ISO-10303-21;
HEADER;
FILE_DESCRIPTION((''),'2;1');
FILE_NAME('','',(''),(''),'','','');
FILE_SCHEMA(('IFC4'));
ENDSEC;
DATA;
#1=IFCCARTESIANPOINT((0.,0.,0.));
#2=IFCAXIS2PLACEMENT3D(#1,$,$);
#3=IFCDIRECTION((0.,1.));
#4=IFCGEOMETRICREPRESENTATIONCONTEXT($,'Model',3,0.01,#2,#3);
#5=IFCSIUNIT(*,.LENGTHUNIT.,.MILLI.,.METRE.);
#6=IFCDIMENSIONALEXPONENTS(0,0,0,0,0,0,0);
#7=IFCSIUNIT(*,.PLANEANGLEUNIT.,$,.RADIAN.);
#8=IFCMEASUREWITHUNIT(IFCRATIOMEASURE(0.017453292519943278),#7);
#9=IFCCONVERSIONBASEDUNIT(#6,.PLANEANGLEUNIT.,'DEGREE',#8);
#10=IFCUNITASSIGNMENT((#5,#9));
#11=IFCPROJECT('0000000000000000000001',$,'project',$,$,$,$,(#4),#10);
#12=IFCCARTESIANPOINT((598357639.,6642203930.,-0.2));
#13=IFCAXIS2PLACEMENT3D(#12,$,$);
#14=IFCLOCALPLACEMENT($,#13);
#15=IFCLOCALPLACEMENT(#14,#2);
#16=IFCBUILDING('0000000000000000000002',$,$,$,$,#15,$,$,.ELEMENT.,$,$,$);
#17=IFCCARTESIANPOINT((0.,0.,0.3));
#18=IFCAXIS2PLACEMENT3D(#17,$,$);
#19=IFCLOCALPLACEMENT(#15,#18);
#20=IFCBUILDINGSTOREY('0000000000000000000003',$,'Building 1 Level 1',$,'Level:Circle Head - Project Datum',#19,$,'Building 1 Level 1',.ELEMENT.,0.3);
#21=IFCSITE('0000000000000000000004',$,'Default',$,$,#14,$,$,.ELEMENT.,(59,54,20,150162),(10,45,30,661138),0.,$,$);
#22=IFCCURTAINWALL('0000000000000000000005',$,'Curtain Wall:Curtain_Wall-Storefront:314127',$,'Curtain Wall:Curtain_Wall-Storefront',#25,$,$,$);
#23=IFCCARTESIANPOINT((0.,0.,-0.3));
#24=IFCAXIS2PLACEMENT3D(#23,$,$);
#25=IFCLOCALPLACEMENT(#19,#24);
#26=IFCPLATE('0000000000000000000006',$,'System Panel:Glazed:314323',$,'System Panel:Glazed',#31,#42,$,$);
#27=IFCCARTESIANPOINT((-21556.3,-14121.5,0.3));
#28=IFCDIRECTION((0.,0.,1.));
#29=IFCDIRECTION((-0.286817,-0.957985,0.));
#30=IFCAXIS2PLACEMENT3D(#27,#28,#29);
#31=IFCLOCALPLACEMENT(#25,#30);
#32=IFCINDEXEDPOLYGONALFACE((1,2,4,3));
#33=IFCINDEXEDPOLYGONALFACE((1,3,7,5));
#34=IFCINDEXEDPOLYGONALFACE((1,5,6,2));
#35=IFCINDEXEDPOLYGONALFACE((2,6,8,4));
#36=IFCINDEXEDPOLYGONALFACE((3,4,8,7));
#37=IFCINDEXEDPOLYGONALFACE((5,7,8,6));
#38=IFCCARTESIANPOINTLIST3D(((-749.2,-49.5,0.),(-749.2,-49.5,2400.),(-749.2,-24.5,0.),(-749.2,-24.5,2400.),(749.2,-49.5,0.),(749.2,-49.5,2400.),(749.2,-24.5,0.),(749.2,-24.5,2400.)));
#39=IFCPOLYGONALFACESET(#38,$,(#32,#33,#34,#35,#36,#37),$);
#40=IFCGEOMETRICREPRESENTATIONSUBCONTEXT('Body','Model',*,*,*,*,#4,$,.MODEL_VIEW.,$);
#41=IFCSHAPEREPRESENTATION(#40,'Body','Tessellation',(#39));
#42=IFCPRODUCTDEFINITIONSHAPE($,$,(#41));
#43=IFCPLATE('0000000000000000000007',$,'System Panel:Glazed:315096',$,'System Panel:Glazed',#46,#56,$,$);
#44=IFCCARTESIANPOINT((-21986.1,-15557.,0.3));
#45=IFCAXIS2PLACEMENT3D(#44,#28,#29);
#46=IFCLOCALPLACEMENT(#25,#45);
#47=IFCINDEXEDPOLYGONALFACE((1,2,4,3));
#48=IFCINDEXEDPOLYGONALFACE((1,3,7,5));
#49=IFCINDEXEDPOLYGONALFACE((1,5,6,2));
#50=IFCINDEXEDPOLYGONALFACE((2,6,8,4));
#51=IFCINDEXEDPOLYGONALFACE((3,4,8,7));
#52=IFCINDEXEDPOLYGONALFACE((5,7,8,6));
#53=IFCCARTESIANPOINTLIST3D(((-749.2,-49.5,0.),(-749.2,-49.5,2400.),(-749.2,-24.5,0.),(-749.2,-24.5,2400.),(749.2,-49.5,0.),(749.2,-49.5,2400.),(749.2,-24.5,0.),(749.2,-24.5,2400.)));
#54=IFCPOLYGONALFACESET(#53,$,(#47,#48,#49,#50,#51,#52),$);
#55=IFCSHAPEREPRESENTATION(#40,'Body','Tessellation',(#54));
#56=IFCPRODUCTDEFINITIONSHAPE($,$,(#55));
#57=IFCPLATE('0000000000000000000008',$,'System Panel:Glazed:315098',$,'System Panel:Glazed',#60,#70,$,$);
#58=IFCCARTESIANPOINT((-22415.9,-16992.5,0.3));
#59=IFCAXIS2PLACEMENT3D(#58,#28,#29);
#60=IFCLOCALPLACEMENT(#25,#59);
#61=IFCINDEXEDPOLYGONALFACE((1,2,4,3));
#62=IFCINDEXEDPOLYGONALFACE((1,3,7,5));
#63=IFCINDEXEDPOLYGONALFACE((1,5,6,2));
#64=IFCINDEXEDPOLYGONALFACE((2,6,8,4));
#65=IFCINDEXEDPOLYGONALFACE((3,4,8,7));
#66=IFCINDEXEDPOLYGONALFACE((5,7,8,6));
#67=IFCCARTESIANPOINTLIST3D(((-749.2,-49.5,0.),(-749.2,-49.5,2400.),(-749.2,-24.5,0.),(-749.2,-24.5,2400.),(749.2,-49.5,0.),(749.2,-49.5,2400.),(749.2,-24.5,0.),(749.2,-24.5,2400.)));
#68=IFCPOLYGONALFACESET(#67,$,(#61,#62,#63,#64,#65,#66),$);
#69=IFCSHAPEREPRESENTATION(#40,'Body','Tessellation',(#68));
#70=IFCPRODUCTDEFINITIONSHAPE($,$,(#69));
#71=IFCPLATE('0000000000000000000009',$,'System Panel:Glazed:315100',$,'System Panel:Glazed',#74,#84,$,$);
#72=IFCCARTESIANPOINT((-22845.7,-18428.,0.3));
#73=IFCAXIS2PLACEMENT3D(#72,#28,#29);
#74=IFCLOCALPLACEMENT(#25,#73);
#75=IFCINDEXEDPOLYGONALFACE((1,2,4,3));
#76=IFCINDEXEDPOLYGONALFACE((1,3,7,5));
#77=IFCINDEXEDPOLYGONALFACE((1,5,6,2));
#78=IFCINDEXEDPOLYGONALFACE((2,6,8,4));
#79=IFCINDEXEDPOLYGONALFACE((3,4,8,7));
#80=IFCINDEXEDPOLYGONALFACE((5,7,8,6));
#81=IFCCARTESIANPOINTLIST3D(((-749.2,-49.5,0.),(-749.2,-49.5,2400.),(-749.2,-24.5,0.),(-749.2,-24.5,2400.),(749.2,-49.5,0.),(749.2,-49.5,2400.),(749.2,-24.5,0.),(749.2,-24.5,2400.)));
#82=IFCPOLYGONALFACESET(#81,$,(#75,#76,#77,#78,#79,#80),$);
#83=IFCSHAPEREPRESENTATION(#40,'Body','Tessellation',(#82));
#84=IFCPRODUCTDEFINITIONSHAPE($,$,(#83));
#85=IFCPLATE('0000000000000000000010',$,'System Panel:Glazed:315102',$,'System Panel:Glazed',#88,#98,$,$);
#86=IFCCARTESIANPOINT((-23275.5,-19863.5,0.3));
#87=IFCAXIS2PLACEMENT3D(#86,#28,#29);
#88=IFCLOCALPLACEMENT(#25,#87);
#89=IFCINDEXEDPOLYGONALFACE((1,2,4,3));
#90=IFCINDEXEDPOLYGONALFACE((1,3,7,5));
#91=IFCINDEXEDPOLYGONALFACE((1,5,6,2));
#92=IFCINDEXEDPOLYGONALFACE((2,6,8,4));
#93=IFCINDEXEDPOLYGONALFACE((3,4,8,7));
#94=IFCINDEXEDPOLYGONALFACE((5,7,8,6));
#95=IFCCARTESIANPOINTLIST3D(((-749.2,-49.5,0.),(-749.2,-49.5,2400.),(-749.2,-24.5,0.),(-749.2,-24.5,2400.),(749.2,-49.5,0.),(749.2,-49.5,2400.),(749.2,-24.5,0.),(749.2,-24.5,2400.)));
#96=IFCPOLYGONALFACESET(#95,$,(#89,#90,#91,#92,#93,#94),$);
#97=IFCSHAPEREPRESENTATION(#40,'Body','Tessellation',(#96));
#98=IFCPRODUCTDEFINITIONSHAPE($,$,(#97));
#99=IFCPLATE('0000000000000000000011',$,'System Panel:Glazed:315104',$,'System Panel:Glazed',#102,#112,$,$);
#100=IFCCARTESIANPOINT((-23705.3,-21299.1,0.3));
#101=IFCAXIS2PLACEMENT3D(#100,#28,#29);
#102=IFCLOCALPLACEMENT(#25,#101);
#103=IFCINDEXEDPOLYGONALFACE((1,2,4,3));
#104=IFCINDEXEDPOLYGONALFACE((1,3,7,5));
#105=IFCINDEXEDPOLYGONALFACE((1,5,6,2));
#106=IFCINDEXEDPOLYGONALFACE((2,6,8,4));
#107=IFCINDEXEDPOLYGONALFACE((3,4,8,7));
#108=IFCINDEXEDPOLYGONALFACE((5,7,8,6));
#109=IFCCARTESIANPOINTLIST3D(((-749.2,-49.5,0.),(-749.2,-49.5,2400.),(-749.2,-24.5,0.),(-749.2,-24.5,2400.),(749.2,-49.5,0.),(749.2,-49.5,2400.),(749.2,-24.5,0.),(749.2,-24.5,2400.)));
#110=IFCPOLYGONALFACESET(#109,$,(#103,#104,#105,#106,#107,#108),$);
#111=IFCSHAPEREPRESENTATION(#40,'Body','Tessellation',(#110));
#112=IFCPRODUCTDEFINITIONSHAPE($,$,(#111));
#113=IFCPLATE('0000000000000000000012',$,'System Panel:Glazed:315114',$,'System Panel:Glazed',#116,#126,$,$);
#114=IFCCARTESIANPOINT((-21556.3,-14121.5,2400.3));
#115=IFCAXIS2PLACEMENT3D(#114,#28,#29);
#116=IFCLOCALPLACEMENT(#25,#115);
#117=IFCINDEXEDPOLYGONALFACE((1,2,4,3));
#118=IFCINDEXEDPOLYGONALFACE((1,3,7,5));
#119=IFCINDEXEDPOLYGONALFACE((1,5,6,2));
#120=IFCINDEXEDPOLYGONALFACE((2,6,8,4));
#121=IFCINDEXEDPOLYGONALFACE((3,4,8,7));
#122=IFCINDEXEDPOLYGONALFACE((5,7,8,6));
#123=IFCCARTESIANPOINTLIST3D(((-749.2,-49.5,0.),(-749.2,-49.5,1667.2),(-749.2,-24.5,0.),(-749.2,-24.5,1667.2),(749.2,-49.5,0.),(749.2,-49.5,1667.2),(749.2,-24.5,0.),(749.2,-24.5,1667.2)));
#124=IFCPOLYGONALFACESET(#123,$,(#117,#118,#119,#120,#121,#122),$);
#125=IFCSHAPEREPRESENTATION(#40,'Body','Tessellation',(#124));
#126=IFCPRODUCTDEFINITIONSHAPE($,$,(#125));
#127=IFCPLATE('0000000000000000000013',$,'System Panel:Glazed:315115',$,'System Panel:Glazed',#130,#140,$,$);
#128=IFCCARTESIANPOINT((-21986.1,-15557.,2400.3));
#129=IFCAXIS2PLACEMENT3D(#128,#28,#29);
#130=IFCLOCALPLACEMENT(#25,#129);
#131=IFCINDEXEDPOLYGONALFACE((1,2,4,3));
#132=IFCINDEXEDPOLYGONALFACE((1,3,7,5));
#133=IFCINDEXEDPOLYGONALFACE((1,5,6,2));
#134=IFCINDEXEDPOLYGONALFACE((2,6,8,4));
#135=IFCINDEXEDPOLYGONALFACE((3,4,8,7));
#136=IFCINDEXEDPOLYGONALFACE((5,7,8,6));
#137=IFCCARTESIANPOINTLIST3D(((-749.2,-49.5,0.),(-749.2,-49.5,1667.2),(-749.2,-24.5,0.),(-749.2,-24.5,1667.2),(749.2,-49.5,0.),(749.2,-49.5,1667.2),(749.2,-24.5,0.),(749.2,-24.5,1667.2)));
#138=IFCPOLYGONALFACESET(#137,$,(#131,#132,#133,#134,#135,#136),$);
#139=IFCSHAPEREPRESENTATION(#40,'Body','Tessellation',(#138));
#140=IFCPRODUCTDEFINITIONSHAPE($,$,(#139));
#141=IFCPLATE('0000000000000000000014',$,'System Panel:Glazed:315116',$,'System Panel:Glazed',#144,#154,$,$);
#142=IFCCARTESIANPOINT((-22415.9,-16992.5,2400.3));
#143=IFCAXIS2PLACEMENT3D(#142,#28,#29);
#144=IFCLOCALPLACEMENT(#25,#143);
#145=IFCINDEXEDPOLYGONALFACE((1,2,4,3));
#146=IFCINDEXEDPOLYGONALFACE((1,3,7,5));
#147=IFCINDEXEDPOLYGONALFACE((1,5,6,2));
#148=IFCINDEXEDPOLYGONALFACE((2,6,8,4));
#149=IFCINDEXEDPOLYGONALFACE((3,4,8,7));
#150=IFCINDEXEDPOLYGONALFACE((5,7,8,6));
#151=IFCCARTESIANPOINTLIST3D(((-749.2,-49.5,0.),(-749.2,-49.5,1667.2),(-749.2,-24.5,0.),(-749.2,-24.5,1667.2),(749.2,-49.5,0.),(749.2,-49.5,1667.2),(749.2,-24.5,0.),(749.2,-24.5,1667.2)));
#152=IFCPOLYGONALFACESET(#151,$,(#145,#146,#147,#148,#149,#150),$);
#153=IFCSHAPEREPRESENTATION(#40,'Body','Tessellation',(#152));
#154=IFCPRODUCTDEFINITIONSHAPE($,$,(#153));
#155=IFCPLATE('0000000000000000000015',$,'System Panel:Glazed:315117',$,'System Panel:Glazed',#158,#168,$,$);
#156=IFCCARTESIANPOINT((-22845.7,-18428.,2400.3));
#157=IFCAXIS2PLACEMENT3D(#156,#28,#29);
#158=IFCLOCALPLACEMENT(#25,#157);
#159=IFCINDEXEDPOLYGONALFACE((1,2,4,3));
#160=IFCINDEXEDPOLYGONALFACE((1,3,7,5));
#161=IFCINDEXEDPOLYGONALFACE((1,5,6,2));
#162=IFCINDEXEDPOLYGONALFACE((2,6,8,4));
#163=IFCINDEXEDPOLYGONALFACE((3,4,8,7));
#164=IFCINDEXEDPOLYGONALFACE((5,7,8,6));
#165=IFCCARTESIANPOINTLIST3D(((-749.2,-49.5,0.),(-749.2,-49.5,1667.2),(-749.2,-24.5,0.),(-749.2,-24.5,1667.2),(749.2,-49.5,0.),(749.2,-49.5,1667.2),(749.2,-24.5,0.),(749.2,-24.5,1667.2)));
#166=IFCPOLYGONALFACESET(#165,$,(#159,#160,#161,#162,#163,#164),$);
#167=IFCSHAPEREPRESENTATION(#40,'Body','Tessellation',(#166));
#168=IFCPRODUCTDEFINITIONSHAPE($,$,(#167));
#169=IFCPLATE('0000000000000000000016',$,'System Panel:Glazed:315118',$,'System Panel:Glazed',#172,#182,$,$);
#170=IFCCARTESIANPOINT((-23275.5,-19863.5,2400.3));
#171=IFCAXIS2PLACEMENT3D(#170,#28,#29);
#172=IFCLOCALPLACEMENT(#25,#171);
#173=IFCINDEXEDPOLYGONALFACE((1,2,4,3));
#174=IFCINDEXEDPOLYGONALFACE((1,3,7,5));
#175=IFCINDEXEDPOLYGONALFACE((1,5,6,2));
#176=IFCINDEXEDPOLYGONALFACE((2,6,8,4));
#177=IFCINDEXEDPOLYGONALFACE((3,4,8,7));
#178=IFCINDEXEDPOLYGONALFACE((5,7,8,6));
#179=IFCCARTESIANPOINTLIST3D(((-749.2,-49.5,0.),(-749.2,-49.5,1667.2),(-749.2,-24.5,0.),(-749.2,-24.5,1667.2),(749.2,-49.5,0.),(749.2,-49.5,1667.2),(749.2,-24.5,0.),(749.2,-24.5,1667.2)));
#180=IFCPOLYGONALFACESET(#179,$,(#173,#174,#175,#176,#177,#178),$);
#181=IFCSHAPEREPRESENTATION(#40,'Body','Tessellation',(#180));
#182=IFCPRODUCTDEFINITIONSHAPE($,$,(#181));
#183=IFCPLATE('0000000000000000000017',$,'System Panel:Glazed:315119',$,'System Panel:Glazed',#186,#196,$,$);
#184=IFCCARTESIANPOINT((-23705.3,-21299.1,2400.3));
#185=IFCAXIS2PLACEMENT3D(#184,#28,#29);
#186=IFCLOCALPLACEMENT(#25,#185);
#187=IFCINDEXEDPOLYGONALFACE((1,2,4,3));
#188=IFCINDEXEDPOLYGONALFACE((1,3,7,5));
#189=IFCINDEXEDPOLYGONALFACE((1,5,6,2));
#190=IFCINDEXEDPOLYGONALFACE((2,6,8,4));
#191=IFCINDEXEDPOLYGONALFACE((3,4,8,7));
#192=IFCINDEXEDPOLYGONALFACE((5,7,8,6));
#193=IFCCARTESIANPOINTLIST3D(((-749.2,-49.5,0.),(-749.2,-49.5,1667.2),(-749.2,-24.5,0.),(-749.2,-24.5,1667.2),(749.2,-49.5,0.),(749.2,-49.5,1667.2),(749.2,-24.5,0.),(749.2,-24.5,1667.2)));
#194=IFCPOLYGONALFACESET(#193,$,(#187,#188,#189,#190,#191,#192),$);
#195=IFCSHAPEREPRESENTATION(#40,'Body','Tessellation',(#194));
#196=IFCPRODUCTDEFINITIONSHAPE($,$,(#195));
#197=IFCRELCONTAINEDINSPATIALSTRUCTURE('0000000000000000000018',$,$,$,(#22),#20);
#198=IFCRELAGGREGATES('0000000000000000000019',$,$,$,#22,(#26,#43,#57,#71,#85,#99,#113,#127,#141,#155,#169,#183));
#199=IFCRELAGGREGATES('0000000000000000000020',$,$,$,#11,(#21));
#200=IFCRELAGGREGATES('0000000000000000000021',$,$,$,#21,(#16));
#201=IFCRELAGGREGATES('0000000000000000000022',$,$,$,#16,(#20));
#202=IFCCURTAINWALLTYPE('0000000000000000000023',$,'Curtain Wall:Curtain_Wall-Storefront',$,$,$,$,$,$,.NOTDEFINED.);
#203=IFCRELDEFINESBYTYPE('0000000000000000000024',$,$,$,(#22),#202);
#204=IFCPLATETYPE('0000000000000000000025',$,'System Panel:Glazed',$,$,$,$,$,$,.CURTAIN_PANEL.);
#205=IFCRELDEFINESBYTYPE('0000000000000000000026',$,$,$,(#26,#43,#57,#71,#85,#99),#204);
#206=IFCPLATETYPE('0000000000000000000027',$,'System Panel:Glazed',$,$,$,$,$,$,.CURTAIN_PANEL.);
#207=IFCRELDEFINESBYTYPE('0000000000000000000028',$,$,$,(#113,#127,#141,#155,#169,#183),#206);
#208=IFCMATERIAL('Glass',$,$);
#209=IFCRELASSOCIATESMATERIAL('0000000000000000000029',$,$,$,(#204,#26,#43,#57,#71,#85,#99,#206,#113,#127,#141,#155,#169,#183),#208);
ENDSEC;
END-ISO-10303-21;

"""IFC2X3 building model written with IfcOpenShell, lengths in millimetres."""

from ifc_helpers import new_model, entity, si_unit, converted_unit, direction, frame, frame_2d, origin, place, context, subcontext, project, spatial, rectangle, extrude, source, transform, mapped, material, type_object, type_shapes, element, aggregate, save


model = new_model("IFC2X3")

# Units and contexts
model_context = context("Model", 3, precision=0.01, world=origin(), true_north=direction((0.0, 1.0)))
body_context = subcontext(model_context, "Body", "Model", "MODEL_VIEW")
ifc_project = project(units=[si_unit("LENGTHUNIT", "METRE", prefix="MILLI"), converted_unit("PLANEANGLEUNIT", "DEGREE", entity("IfcRatioMeasure", 0.017453292519943278), si_unit("PLANEANGLEUNIT", "RADIAN"), dimensions=[0, 0, 0, 0, 0, 0, 0])], contexts=[model_context])

# Site, building, storey
site_placement = place(None, frame((598357639.0, 6642203930.0, -0.2)))
site = spatial("IfcSite", under=ifc_project, at=site_placement, Name="Default", CompositionType="ELEMENT", RefLatitude=(59, 54, 20, 150162), RefLongitude=(10, 45, 30, 661138), RefElevation=0.0)
building_placement = place(site_placement, origin())
building = spatial("IfcBuilding", under=site, at=building_placement, CompositionType="ELEMENT")
storey_placement = place(building_placement, frame((0.0, 0.0, 0.3)))
storey = spatial("IfcBuildingStorey", under=building, at=storey_placement, Name="Building 1 Level 1", ObjectType="Level:Circle Head - Project Datum", LongName="Building 1 Level 1", CompositionType="ELEMENT", Elevation=0.3)

# Curtain wall, plates
curtain_wall_type = type_object("IfcCurtainWallType", Name="Curtain Wall:Curtain_Wall-Storefront", PredefinedType="NOTDEFINED")
curtain_wall_1_placement = place(storey_placement, frame((0.0, 0.0, -0.3)))
curtain_wall_1 = element("IfcCurtainWall", 1, at=curtain_wall_1_placement, inside=storey, type_object=curtain_wall_type, Name="Curtain Wall:Curtain_Wall-Storefront:314127", ObjectType="Curtain Wall:Curtain_Wall-Storefront")
ifc_material = material(Name="Glass")
plate_type_1 = type_object("IfcPlateType", Name="System Panel:Glazed", PredefinedType="CURTAIN_PANEL", material=ifc_material)
shared_shape_1 = source(origin(), body_context, "Body", "SweptSolid", [
    extrude(rectangle(XDim=25.0, YDim=1498.5, at=frame_2d((0.0, 0.0), x_axis=(1.0, 0.0))), frame((0.0, -37.0, 0.0), z_axis=(0.0, 0.0, 1.0), x_axis=(0.0, 1.0, 0.0)), (0.0, 0.0, 1.0), 2400.0),
])
type_shapes(plate_type_1, [shared_shape_1])
plate_1_placement = place(curtain_wall_1_placement, frame((-21556.3, -14121.5, 0.3), z_axis=(0.0, 0.0, 1.0), x_axis=(-0.286817, -0.957985, 0.0)))
plate_1 = element("IfcPlate", 2, at=plate_1_placement, type_object=plate_type_1, material=ifc_material, Name="System Panel:Glazed:314323", ObjectType="System Panel:Glazed", context=body_context, shape_type="MappedRepresentation", body=[
    mapped(shared_shape_1, transform((0.0, 0.0, 0.0), scale=1.0)),
])
plate_2_placement = place(curtain_wall_1_placement, frame((-21986.1, -15557.0, 0.3), z_axis=(0.0, 0.0, 1.0), x_axis=(-0.286817, -0.957985, 0.0)))
plate_2 = element("IfcPlate", 3, at=plate_2_placement, type_object=plate_type_1, material=ifc_material, Name="System Panel:Glazed:315096", ObjectType="System Panel:Glazed", context=body_context, shape_type="MappedRepresentation", body=[
    mapped(shared_shape_1, transform((0.0, 0.0, 0.0), scale=1.0)),
])
plate_3_placement = place(curtain_wall_1_placement, frame((-22415.9, -16992.5, 0.3), z_axis=(0.0, 0.0, 1.0), x_axis=(-0.286817, -0.957985, 0.0)))
plate_3 = element("IfcPlate", 4, at=plate_3_placement, type_object=plate_type_1, material=ifc_material, Name="System Panel:Glazed:315098", ObjectType="System Panel:Glazed", context=body_context, shape_type="MappedRepresentation", body=[
    mapped(shared_shape_1, transform((0.0, 0.0, 0.0), scale=1.0)),
])
plate_4_placement = place(curtain_wall_1_placement, frame((-22845.7, -18428.0, 0.3), z_axis=(0.0, 0.0, 1.0), x_axis=(-0.286817, -0.957985, 0.0)))
plate_4 = element("IfcPlate", 5, at=plate_4_placement, type_object=plate_type_1, material=ifc_material, Name="System Panel:Glazed:315100", ObjectType="System Panel:Glazed", context=body_context, shape_type="MappedRepresentation", body=[
    mapped(shared_shape_1, transform((0.0, 0.0, 0.0), scale=1.0)),
])
plate_5_placement = place(curtain_wall_1_placement, frame((-23275.5, -19863.5, 0.3), z_axis=(0.0, 0.0, 1.0), x_axis=(-0.286817, -0.957985, 0.0)))
plate_5 = element("IfcPlate", 6, at=plate_5_placement, type_object=plate_type_1, material=ifc_material, Name="System Panel:Glazed:315102", ObjectType="System Panel:Glazed", context=body_context, shape_type="MappedRepresentation", body=[
    mapped(shared_shape_1, transform((0.0, 0.0, 0.0), scale=1.0)),
])
plate_6_placement = place(curtain_wall_1_placement, frame((-23705.3, -21299.1, 0.3), z_axis=(0.0, 0.0, 1.0), x_axis=(-0.286817, -0.957985, 0.0)))
plate_6 = element("IfcPlate", 7, at=plate_6_placement, type_object=plate_type_1, material=ifc_material, Name="System Panel:Glazed:315104", ObjectType="System Panel:Glazed", context=body_context, shape_type="MappedRepresentation", body=[
    mapped(shared_shape_1, transform((0.0, 0.0, 0.0), scale=1.0)),
])
plate_type_2 = type_object("IfcPlateType", Name="System Panel:Glazed", PredefinedType="CURTAIN_PANEL", material=ifc_material)
shared_shape_2 = source(origin(), body_context, "Body", "SweptSolid", [
    extrude(rectangle(XDim=25.0, YDim=1498.5, at=frame_2d((0.0, 0.0), x_axis=(1.0, 0.0))), frame((0.0, -37.0, 0.0), z_axis=(0.0, 0.0, 1.0), x_axis=(0.0, 1.0, 0.0)), (0.0, 0.0, 1.0), 1667.2),
])
type_shapes(plate_type_2, [shared_shape_2])
plate_7_placement = place(curtain_wall_1_placement, frame((-21556.3, -14121.5, 2400.3), z_axis=(0.0, 0.0, 1.0), x_axis=(-0.286817, -0.957985, 0.0)))
plate_7 = element("IfcPlate", 8, at=plate_7_placement, type_object=plate_type_2, material=ifc_material, Name="System Panel:Glazed:315114", ObjectType="System Panel:Glazed", context=body_context, shape_type="MappedRepresentation", body=[
    mapped(shared_shape_2, transform((0.0, 0.0, 0.0), scale=1.0)),
])
plate_8_placement = place(curtain_wall_1_placement, frame((-21986.1, -15557.0, 2400.3), z_axis=(0.0, 0.0, 1.0), x_axis=(-0.286817, -0.957985, 0.0)))
plate_8 = element("IfcPlate", 9, at=plate_8_placement, type_object=plate_type_2, material=ifc_material, Name="System Panel:Glazed:315115", ObjectType="System Panel:Glazed", context=body_context, shape_type="MappedRepresentation", body=[
    mapped(shared_shape_2, transform((0.0, 0.0, 0.0), scale=1.0)),
])
plate_9_placement = place(curtain_wall_1_placement, frame((-22415.9, -16992.5, 2400.3), z_axis=(0.0, 0.0, 1.0), x_axis=(-0.286817, -0.957985, 0.0)))
plate_9 = element("IfcPlate", 10, at=plate_9_placement, type_object=plate_type_2, material=ifc_material, Name="System Panel:Glazed:315116", ObjectType="System Panel:Glazed", context=body_context, shape_type="MappedRepresentation", body=[
    mapped(shared_shape_2, transform((0.0, 0.0, 0.0), scale=1.0)),
])
plate_10_placement = place(curtain_wall_1_placement, frame((-22845.7, -18428.0, 2400.3), z_axis=(0.0, 0.0, 1.0), x_axis=(-0.286817, -0.957985, 0.0)))
plate_10 = element("IfcPlate", 11, at=plate_10_placement, type_object=plate_type_2, material=ifc_material, Name="System Panel:Glazed:315117", ObjectType="System Panel:Glazed", context=body_context, shape_type="MappedRepresentation", body=[
    mapped(shared_shape_2, transform((0.0, 0.0, 0.0), scale=1.0)),
])
plate_11_placement = place(curtain_wall_1_placement, frame((-23275.5, -19863.5, 2400.3), z_axis=(0.0, 0.0, 1.0), x_axis=(-0.286817, -0.957985, 0.0)))
plate_11 = element("IfcPlate", 12, at=plate_11_placement, type_object=plate_type_2, material=ifc_material, Name="System Panel:Glazed:315118", ObjectType="System Panel:Glazed", context=body_context, shape_type="MappedRepresentation", body=[
    mapped(shared_shape_2, transform((0.0, 0.0, 0.0), scale=1.0)),
])
plate_12_placement = place(curtain_wall_1_placement, frame((-23705.3, -21299.1, 2400.3), z_axis=(0.0, 0.0, 1.0), x_axis=(-0.286817, -0.957985, 0.0)))
plate_12 = element("IfcPlate", 13, at=plate_12_placement, type_object=plate_type_2, material=ifc_material, Name="System Panel:Glazed:315119", ObjectType="System Panel:Glazed", context=body_context, shape_type="MappedRepresentation", body=[
    mapped(shared_shape_2, transform((0.0, 0.0, 0.0), scale=1.0)),
])
aggregate(curtain_wall_1, [plate_1, plate_2, plate_3, plate_4, plate_5, plate_6, plate_7, plate_8, plate_9, plate_10, plate_11, plate_12])

save(model, "model.ifc")
